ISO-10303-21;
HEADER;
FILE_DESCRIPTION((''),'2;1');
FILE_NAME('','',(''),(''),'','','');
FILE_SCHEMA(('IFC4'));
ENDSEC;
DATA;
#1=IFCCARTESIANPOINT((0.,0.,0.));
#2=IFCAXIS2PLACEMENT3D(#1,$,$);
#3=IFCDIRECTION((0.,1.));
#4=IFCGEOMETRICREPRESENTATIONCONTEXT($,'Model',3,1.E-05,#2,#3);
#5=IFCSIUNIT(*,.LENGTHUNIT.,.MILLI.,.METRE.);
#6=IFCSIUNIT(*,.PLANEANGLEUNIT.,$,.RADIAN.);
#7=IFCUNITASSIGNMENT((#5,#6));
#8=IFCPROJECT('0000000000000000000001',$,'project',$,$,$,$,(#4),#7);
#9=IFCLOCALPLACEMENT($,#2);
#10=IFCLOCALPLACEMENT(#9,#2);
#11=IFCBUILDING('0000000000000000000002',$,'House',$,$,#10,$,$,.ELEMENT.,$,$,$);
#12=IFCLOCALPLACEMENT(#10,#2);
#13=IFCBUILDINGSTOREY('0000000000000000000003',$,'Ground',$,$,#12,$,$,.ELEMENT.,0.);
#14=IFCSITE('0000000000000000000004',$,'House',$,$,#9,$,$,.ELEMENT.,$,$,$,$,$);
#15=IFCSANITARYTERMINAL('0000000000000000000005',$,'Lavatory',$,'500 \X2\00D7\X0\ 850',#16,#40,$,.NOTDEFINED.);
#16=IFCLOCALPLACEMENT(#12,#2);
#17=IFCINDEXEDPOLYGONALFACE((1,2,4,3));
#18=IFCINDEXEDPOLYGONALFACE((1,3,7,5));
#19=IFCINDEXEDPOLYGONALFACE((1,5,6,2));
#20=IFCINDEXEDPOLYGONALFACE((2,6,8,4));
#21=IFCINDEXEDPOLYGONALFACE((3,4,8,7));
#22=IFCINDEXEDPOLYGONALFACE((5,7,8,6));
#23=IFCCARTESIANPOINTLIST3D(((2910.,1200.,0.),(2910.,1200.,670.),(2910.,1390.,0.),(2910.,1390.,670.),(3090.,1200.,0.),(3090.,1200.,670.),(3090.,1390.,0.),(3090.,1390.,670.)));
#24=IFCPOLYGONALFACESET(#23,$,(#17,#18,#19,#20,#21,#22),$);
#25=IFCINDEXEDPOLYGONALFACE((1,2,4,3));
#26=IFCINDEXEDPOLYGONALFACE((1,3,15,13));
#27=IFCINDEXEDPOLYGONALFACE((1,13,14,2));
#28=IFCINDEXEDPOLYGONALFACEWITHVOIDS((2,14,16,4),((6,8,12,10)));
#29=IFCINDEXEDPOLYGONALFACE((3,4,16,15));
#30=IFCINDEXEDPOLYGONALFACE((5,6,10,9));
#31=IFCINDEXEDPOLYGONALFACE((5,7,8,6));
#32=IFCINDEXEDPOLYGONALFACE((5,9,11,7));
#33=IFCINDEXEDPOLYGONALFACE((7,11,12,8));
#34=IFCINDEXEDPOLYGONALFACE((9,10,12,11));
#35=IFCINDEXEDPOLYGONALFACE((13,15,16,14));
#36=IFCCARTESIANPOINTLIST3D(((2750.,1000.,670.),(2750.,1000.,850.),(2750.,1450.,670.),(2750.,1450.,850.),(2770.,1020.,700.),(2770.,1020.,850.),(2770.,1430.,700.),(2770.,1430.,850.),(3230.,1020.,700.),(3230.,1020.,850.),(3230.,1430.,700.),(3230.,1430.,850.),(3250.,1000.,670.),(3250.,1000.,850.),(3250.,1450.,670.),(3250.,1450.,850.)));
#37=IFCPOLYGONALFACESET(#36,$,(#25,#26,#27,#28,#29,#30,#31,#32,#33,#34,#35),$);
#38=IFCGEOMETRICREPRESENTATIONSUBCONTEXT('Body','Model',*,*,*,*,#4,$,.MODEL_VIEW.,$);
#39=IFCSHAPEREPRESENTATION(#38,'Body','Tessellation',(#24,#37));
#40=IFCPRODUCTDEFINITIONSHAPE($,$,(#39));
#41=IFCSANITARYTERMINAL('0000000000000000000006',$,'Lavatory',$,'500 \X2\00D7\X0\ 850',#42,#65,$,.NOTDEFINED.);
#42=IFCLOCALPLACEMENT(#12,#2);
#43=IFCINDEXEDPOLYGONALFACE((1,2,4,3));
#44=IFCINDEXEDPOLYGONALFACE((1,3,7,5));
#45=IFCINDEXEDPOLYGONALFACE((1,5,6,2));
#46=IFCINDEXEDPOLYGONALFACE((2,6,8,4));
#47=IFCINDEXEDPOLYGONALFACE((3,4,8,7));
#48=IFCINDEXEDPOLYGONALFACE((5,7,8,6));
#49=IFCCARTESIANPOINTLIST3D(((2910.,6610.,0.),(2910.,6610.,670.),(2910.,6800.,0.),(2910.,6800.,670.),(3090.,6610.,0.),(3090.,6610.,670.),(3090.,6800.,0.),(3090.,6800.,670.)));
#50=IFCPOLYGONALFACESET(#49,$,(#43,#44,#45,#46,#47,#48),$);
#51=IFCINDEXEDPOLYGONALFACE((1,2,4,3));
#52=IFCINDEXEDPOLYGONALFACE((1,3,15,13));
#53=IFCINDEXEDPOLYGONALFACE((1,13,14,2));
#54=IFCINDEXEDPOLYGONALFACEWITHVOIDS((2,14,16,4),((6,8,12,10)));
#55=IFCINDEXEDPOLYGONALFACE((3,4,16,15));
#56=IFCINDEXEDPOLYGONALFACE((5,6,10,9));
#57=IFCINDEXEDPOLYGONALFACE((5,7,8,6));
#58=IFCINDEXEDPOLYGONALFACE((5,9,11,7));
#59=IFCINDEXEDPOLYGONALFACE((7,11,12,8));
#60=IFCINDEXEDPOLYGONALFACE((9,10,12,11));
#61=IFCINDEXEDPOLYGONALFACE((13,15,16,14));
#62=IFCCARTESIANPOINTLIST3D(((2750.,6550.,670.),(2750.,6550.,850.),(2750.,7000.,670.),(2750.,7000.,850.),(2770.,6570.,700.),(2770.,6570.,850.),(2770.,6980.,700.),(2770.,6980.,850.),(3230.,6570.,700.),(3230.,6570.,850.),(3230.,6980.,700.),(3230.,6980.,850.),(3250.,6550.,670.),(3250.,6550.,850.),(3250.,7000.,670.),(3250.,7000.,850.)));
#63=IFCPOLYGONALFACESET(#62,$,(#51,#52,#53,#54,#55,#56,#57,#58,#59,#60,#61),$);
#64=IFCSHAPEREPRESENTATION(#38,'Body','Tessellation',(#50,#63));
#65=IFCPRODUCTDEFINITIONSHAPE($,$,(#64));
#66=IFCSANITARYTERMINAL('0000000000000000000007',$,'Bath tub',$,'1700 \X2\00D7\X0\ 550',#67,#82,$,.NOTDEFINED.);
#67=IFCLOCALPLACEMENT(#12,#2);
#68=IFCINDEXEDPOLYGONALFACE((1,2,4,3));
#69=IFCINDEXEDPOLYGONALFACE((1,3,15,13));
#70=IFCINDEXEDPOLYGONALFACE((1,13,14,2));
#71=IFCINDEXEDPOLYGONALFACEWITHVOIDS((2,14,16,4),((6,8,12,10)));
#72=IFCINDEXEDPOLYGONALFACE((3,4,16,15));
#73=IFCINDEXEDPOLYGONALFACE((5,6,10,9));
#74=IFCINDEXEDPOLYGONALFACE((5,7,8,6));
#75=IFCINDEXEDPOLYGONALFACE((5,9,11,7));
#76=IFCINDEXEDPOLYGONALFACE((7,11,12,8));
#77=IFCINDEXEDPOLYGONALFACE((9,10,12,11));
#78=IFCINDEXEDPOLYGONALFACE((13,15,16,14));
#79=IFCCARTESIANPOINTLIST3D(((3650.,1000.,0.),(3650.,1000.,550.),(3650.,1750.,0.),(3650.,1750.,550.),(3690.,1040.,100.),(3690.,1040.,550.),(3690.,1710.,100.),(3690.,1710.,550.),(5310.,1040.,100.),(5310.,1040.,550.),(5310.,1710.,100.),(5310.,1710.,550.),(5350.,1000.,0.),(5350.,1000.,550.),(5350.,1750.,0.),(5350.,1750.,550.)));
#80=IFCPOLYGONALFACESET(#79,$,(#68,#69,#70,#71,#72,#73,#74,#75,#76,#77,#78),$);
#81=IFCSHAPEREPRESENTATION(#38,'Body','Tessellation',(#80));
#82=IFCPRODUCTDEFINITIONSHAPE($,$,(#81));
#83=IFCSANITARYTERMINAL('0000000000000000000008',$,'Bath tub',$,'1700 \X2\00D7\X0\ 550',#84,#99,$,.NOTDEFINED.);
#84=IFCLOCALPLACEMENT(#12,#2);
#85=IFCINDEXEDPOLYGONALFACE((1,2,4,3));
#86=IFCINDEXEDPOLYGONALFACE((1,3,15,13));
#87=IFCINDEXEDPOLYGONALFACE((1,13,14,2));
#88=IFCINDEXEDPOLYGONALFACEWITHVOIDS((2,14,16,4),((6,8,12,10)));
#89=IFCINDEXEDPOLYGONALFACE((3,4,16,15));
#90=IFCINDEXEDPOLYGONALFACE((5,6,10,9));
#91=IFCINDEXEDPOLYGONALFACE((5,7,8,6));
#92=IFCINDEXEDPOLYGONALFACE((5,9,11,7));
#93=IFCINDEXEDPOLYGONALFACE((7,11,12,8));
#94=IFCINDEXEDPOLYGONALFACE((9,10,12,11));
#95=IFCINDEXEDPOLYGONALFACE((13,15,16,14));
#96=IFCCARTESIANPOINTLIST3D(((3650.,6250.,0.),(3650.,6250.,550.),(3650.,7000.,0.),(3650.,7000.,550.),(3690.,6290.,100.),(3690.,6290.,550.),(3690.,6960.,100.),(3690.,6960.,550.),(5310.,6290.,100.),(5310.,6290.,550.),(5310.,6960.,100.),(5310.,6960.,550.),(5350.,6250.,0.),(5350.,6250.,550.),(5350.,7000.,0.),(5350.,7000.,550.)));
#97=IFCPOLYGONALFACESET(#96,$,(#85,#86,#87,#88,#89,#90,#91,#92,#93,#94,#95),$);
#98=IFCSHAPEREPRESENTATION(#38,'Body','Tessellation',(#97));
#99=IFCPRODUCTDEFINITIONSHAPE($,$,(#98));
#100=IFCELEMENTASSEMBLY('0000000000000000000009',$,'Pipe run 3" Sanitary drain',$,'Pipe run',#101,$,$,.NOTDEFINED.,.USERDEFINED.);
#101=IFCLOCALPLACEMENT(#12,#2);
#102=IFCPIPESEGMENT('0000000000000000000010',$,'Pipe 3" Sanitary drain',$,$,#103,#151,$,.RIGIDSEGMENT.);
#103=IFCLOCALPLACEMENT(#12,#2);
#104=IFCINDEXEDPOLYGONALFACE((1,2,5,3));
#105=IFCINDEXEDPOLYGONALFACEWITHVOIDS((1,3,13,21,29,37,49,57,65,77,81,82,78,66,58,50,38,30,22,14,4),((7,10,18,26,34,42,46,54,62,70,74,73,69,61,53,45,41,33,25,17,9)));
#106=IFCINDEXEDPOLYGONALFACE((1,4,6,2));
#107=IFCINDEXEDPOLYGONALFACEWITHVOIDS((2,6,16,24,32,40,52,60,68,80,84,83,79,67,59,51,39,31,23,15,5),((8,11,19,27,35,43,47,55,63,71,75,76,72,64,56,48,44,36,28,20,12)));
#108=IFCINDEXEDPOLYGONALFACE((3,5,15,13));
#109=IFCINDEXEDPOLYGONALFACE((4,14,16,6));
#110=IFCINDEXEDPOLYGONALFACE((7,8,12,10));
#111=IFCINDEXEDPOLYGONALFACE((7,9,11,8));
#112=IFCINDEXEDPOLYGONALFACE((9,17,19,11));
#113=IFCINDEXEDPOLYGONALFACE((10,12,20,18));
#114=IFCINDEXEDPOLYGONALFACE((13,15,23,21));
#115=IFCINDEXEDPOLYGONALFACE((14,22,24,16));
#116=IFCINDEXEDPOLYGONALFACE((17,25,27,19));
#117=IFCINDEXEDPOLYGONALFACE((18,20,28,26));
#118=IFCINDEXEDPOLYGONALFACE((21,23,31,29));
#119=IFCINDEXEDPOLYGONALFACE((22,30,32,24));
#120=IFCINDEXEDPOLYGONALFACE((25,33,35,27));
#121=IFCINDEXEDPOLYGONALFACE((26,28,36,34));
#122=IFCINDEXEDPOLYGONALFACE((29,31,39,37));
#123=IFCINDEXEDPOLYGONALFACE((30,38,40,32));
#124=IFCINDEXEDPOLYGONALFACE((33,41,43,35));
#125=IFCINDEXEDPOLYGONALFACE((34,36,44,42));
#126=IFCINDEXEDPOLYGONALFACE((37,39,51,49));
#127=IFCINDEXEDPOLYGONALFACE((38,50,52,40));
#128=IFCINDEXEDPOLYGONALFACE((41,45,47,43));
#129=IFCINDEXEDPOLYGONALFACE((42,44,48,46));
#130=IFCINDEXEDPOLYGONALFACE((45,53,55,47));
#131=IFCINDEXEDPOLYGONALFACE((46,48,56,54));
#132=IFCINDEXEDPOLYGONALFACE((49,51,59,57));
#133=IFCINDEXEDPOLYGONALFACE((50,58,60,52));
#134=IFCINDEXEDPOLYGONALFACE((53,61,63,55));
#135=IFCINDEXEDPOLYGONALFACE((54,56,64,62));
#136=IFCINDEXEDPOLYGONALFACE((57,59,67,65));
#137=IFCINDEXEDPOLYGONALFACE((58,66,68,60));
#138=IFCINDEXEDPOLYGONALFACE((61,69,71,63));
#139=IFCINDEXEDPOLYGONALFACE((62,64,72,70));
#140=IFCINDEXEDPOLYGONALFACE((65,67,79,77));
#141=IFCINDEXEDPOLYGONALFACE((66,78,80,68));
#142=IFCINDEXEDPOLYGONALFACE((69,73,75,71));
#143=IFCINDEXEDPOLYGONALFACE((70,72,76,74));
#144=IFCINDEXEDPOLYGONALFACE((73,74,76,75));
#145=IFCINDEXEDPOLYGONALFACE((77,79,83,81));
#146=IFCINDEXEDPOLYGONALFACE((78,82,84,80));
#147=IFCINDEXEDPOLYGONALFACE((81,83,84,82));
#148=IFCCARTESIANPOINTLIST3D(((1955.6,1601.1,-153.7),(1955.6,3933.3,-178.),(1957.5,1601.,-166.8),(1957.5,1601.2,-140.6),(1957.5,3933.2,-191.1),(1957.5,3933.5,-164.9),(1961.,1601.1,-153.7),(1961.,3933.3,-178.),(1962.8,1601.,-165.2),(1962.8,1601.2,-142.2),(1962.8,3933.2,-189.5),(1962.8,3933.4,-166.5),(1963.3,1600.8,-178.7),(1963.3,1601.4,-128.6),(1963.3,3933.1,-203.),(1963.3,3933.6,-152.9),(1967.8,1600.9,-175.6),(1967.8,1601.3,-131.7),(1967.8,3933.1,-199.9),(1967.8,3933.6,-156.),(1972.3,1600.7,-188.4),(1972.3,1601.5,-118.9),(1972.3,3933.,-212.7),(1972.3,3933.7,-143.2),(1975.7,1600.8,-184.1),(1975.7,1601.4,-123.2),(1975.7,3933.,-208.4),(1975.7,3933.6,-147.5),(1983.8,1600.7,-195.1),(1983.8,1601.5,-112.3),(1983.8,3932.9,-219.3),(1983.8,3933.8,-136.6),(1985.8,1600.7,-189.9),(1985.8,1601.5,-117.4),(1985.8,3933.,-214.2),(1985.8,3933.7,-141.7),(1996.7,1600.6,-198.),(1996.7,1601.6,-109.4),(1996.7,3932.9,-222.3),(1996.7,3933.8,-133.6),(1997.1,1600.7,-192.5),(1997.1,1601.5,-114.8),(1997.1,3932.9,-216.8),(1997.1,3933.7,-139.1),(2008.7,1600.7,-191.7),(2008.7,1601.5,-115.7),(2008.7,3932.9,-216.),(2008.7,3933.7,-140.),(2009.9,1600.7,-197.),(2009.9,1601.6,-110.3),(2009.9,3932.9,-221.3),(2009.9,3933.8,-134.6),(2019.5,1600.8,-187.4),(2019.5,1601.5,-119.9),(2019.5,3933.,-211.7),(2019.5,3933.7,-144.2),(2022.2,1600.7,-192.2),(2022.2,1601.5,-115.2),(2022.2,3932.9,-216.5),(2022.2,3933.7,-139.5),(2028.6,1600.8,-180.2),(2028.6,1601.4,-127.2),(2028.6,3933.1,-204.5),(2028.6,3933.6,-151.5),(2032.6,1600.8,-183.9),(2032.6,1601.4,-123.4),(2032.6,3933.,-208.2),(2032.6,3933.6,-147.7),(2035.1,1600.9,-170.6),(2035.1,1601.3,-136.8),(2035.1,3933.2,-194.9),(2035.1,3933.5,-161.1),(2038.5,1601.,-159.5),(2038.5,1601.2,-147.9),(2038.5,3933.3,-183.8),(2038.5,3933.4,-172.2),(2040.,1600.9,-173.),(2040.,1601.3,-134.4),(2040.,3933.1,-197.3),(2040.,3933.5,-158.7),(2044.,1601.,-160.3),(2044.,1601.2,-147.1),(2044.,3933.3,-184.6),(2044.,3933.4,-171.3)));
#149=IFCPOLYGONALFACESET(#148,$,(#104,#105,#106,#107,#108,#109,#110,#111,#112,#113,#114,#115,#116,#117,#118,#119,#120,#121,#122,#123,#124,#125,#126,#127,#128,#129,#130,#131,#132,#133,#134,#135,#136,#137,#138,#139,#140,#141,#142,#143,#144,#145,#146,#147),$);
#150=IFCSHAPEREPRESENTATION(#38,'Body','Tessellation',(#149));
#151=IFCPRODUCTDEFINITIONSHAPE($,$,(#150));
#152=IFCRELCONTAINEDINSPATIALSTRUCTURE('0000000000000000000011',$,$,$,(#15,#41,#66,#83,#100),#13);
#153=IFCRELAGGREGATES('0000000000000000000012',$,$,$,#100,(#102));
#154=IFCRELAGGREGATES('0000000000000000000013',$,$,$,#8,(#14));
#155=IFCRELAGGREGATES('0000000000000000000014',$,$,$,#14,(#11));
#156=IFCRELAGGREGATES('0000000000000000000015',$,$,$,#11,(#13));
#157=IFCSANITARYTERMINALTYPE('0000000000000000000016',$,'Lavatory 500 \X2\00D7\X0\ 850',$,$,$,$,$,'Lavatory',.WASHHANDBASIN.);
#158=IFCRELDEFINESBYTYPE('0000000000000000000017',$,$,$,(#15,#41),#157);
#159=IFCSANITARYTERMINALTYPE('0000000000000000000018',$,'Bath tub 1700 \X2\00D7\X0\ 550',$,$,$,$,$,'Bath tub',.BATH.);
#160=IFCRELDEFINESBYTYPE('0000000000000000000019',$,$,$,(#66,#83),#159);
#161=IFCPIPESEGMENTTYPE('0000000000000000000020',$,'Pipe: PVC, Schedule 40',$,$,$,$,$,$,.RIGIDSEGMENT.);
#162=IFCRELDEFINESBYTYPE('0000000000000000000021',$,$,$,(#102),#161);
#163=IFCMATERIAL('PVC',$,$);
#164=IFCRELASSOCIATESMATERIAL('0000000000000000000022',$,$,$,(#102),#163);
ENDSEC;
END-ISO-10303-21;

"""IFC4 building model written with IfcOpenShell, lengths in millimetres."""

from ifc_helpers import new_model, entity, si_unit, direction, frame, origin, origin_with_axes, origin_2d, place, context, subcontext, project, spatial, polyline, hollow_circle, outline, extrude, source, transform, mapped, material, type_object, type_shapes, element, aggregate, save


model = new_model("IFC4")

# Units and contexts
model_context = context("Model", 3, precision=1e-05, world=origin(), true_north=direction((0.0, 1.0)))
body_context = subcontext(model_context, "Body", "Model", "MODEL_VIEW")
ifc_project = project(units=[si_unit("LENGTHUNIT", "METRE", prefix="MILLI"), si_unit("PLANEANGLEUNIT", "RADIAN")], contexts=[model_context])

# Site, building, storey
site_placement = place(None, origin())
site = spatial("IfcSite", under=ifc_project, at=site_placement, Name="House", CompositionType="ELEMENT")
building_placement = place(site_placement, origin())
building = spatial("IfcBuilding", under=site, at=building_placement, Name="House", CompositionType="ELEMENT")
storey_placement = place(building_placement, origin())
storey = spatial("IfcBuildingStorey", under=building, at=storey_placement, Name="Ground", CompositionType="ELEMENT", Elevation=0.0)

# Sanitary terminals
sanitary_terminal_type_1 = type_object("IfcSanitaryTerminalType", Name="Lavatory 500 × 850", ElementType="Lavatory", PredefinedType="WASHHANDBASIN")
cartesian_point_1 = entity("IfcCartesianPoint", [-250.0, 0.0])
cartesian_point_2 = entity("IfcCartesianPoint", [-230.0, 20.0])
shared_shape_1 = source(origin(), body_context, "Body", "SolidModel", [
    extrude(outline(polyline([(-90.0, 200.0), (90.0, 200.0), (90.0, 390.0), (-90.0, 390.0), (-90.0, 200.0)])), origin(), (0.0, 0.0, 1.0), 670.0),
    entity("IfcCsgSolid", entity("IfcBooleanResult", "DIFFERENCE", entity("IfcExtrudedAreaSolid", entity("IfcArbitraryClosedProfileDef", "AREA", None, entity("IfcPolyline", [cartesian_point_1, entity("IfcCartesianPoint", [250.0, 0.0]), entity("IfcCartesianPoint", [250.0, 450.0]), entity("IfcCartesianPoint", [-250.0, 450.0]), cartesian_point_1])), entity("IfcAxis2Placement3D", entity("IfcCartesianPoint", [0.0, 0.0, 670.0])), entity("IfcDirection", [0.0, 0.0, 1.0]), 180.0), entity("IfcExtrudedAreaSolid", entity("IfcArbitraryClosedProfileDef", "AREA", None, entity("IfcPolyline", [cartesian_point_2, entity("IfcCartesianPoint", [230.0, 20.0]), entity("IfcCartesianPoint", [230.0, 430.0]), entity("IfcCartesianPoint", [-230.0, 430.0]), cartesian_point_2])), entity("IfcAxis2Placement3D", entity("IfcCartesianPoint", [0.0, 0.0, 700.0])), entity("IfcDirection", [0.0, 0.0, 1.0]), 151.0))),
])
type_shapes(sanitary_terminal_type_1, [shared_shape_1])
for number, where, z_axis, x_axis, name in (
    (1, (3000.0, 1000.0, 0.0), (0.0, 0.0, 1.0), (1.0, 0.0, 0.0), "Lavatory"),
    (2, (3000.0, 7000.0, 0.0), (0.0, 0.0, 1.0), (-1.0, 0.0, 0.0), "Lavatory"),
):
    element("IfcSanitaryTerminal", number, at=place(storey_placement, frame(where, z_axis=z_axis, x_axis=x_axis)), inside=storey, type_object=sanitary_terminal_type_1, Name=name, ObjectType="500 × 850", PredefinedType="NOTDEFINED", context=body_context, shape_type="MappedRepresentation", body=[
        mapped(shared_shape_1, transform((0.0, 0.0, 0.0))),
    ])
sanitary_terminal_type_2 = type_object("IfcSanitaryTerminalType", Name="Bath tub 1700 × 550", ElementType="Bath tub", PredefinedType="BATH")
cartesian_point_3 = entity("IfcCartesianPoint", [-850.0, 0.0])
cartesian_point_4 = entity("IfcCartesianPoint", [-810.0, 40.0])
shared_shape_2 = source(origin(), body_context, "Body", "SolidModel", [
    entity("IfcCsgSolid", entity("IfcBooleanResult", "DIFFERENCE", entity("IfcExtrudedAreaSolid", entity("IfcArbitraryClosedProfileDef", "AREA", None, entity("IfcPolyline", [cartesian_point_3, entity("IfcCartesianPoint", [850.0, 0.0]), entity("IfcCartesianPoint", [850.0, 750.0]), entity("IfcCartesianPoint", [-850.0, 750.0]), cartesian_point_3])), entity("IfcAxis2Placement3D", entity("IfcCartesianPoint", [0.0, 0.0, 0.0])), entity("IfcDirection", [0.0, 0.0, 1.0]), 550.0), entity("IfcExtrudedAreaSolid", entity("IfcArbitraryClosedProfileDef", "AREA", None, entity("IfcPolyline", [cartesian_point_4, entity("IfcCartesianPoint", [810.0, 40.0]), entity("IfcCartesianPoint", [810.0, 710.0]), entity("IfcCartesianPoint", [-810.0, 710.0]), cartesian_point_4])), entity("IfcAxis2Placement3D", entity("IfcCartesianPoint", [0.0, 0.0, 100.0])), entity("IfcDirection", [0.0, 0.0, 1.0]), 451.0))),
])
type_shapes(sanitary_terminal_type_2, [shared_shape_2])
for number, where, z_axis, x_axis, name in (
    (3, (4500.0, 1000.0, 0.0), (0.0, 0.0, 1.0), (1.0, 0.0, 0.0), "Bath tub"),
    (4, (4500.0, 7000.0, 0.0), (0.0, 0.0, 1.0), (-1.0, 0.0, 0.0), "Bath tub"),
):
    element("IfcSanitaryTerminal", number, at=place(storey_placement, frame(where, z_axis=z_axis, x_axis=x_axis)), inside=storey, type_object=sanitary_terminal_type_2, Name=name, ObjectType="1700 × 550", PredefinedType="NOTDEFINED", context=body_context, shape_type="MappedRepresentation", body=[
        mapped(shared_shape_2, transform((0.0, 0.0, 0.0))),
    ])

# Element assembly, pipe segment
assembly_1_placement = place(storey_placement, origin_with_axes())
assembly_1 = element("IfcElementAssembly", 5, at=assembly_1_placement, inside=storey, Name="Pipe run 3\" Sanitary drain", ObjectType="Pipe run", AssemblyPlace="NOTDEFINED", PredefinedType="USERDEFINED")
ifc_material = material(Name="PVC")
pipe_segment_type = type_object("IfcPipeSegmentType", Name="Pipe: PVC, Schedule 40", PredefinedType="RIGIDSEGMENT")
pipe_segment_1_placement = place(storey_placement, origin_with_axes())
pipe_segment_1 = element("IfcPipeSegment", 6, at=pipe_segment_1_placement, type_object=pipe_segment_type, material=ifc_material, Name="Pipe 3\" Sanitary drain", PredefinedType="RIGIDSEGMENT", context=body_context, shape_type="SweptSolid", body=[
    extrude(hollow_circle(Radius=44.5, WallThickness=5.5, at=origin_2d()), frame((2000.0, 1601.1, -153.7), z_axis=(0.0, 0.999946, -0.010416), x_axis=(-1.0, 0.0, 0.0)), (0.0, 0.0, 1.0), 2332.4),
])

aggregate(assembly_1, [pipe_segment_1])

save(model, "model.ifc")
